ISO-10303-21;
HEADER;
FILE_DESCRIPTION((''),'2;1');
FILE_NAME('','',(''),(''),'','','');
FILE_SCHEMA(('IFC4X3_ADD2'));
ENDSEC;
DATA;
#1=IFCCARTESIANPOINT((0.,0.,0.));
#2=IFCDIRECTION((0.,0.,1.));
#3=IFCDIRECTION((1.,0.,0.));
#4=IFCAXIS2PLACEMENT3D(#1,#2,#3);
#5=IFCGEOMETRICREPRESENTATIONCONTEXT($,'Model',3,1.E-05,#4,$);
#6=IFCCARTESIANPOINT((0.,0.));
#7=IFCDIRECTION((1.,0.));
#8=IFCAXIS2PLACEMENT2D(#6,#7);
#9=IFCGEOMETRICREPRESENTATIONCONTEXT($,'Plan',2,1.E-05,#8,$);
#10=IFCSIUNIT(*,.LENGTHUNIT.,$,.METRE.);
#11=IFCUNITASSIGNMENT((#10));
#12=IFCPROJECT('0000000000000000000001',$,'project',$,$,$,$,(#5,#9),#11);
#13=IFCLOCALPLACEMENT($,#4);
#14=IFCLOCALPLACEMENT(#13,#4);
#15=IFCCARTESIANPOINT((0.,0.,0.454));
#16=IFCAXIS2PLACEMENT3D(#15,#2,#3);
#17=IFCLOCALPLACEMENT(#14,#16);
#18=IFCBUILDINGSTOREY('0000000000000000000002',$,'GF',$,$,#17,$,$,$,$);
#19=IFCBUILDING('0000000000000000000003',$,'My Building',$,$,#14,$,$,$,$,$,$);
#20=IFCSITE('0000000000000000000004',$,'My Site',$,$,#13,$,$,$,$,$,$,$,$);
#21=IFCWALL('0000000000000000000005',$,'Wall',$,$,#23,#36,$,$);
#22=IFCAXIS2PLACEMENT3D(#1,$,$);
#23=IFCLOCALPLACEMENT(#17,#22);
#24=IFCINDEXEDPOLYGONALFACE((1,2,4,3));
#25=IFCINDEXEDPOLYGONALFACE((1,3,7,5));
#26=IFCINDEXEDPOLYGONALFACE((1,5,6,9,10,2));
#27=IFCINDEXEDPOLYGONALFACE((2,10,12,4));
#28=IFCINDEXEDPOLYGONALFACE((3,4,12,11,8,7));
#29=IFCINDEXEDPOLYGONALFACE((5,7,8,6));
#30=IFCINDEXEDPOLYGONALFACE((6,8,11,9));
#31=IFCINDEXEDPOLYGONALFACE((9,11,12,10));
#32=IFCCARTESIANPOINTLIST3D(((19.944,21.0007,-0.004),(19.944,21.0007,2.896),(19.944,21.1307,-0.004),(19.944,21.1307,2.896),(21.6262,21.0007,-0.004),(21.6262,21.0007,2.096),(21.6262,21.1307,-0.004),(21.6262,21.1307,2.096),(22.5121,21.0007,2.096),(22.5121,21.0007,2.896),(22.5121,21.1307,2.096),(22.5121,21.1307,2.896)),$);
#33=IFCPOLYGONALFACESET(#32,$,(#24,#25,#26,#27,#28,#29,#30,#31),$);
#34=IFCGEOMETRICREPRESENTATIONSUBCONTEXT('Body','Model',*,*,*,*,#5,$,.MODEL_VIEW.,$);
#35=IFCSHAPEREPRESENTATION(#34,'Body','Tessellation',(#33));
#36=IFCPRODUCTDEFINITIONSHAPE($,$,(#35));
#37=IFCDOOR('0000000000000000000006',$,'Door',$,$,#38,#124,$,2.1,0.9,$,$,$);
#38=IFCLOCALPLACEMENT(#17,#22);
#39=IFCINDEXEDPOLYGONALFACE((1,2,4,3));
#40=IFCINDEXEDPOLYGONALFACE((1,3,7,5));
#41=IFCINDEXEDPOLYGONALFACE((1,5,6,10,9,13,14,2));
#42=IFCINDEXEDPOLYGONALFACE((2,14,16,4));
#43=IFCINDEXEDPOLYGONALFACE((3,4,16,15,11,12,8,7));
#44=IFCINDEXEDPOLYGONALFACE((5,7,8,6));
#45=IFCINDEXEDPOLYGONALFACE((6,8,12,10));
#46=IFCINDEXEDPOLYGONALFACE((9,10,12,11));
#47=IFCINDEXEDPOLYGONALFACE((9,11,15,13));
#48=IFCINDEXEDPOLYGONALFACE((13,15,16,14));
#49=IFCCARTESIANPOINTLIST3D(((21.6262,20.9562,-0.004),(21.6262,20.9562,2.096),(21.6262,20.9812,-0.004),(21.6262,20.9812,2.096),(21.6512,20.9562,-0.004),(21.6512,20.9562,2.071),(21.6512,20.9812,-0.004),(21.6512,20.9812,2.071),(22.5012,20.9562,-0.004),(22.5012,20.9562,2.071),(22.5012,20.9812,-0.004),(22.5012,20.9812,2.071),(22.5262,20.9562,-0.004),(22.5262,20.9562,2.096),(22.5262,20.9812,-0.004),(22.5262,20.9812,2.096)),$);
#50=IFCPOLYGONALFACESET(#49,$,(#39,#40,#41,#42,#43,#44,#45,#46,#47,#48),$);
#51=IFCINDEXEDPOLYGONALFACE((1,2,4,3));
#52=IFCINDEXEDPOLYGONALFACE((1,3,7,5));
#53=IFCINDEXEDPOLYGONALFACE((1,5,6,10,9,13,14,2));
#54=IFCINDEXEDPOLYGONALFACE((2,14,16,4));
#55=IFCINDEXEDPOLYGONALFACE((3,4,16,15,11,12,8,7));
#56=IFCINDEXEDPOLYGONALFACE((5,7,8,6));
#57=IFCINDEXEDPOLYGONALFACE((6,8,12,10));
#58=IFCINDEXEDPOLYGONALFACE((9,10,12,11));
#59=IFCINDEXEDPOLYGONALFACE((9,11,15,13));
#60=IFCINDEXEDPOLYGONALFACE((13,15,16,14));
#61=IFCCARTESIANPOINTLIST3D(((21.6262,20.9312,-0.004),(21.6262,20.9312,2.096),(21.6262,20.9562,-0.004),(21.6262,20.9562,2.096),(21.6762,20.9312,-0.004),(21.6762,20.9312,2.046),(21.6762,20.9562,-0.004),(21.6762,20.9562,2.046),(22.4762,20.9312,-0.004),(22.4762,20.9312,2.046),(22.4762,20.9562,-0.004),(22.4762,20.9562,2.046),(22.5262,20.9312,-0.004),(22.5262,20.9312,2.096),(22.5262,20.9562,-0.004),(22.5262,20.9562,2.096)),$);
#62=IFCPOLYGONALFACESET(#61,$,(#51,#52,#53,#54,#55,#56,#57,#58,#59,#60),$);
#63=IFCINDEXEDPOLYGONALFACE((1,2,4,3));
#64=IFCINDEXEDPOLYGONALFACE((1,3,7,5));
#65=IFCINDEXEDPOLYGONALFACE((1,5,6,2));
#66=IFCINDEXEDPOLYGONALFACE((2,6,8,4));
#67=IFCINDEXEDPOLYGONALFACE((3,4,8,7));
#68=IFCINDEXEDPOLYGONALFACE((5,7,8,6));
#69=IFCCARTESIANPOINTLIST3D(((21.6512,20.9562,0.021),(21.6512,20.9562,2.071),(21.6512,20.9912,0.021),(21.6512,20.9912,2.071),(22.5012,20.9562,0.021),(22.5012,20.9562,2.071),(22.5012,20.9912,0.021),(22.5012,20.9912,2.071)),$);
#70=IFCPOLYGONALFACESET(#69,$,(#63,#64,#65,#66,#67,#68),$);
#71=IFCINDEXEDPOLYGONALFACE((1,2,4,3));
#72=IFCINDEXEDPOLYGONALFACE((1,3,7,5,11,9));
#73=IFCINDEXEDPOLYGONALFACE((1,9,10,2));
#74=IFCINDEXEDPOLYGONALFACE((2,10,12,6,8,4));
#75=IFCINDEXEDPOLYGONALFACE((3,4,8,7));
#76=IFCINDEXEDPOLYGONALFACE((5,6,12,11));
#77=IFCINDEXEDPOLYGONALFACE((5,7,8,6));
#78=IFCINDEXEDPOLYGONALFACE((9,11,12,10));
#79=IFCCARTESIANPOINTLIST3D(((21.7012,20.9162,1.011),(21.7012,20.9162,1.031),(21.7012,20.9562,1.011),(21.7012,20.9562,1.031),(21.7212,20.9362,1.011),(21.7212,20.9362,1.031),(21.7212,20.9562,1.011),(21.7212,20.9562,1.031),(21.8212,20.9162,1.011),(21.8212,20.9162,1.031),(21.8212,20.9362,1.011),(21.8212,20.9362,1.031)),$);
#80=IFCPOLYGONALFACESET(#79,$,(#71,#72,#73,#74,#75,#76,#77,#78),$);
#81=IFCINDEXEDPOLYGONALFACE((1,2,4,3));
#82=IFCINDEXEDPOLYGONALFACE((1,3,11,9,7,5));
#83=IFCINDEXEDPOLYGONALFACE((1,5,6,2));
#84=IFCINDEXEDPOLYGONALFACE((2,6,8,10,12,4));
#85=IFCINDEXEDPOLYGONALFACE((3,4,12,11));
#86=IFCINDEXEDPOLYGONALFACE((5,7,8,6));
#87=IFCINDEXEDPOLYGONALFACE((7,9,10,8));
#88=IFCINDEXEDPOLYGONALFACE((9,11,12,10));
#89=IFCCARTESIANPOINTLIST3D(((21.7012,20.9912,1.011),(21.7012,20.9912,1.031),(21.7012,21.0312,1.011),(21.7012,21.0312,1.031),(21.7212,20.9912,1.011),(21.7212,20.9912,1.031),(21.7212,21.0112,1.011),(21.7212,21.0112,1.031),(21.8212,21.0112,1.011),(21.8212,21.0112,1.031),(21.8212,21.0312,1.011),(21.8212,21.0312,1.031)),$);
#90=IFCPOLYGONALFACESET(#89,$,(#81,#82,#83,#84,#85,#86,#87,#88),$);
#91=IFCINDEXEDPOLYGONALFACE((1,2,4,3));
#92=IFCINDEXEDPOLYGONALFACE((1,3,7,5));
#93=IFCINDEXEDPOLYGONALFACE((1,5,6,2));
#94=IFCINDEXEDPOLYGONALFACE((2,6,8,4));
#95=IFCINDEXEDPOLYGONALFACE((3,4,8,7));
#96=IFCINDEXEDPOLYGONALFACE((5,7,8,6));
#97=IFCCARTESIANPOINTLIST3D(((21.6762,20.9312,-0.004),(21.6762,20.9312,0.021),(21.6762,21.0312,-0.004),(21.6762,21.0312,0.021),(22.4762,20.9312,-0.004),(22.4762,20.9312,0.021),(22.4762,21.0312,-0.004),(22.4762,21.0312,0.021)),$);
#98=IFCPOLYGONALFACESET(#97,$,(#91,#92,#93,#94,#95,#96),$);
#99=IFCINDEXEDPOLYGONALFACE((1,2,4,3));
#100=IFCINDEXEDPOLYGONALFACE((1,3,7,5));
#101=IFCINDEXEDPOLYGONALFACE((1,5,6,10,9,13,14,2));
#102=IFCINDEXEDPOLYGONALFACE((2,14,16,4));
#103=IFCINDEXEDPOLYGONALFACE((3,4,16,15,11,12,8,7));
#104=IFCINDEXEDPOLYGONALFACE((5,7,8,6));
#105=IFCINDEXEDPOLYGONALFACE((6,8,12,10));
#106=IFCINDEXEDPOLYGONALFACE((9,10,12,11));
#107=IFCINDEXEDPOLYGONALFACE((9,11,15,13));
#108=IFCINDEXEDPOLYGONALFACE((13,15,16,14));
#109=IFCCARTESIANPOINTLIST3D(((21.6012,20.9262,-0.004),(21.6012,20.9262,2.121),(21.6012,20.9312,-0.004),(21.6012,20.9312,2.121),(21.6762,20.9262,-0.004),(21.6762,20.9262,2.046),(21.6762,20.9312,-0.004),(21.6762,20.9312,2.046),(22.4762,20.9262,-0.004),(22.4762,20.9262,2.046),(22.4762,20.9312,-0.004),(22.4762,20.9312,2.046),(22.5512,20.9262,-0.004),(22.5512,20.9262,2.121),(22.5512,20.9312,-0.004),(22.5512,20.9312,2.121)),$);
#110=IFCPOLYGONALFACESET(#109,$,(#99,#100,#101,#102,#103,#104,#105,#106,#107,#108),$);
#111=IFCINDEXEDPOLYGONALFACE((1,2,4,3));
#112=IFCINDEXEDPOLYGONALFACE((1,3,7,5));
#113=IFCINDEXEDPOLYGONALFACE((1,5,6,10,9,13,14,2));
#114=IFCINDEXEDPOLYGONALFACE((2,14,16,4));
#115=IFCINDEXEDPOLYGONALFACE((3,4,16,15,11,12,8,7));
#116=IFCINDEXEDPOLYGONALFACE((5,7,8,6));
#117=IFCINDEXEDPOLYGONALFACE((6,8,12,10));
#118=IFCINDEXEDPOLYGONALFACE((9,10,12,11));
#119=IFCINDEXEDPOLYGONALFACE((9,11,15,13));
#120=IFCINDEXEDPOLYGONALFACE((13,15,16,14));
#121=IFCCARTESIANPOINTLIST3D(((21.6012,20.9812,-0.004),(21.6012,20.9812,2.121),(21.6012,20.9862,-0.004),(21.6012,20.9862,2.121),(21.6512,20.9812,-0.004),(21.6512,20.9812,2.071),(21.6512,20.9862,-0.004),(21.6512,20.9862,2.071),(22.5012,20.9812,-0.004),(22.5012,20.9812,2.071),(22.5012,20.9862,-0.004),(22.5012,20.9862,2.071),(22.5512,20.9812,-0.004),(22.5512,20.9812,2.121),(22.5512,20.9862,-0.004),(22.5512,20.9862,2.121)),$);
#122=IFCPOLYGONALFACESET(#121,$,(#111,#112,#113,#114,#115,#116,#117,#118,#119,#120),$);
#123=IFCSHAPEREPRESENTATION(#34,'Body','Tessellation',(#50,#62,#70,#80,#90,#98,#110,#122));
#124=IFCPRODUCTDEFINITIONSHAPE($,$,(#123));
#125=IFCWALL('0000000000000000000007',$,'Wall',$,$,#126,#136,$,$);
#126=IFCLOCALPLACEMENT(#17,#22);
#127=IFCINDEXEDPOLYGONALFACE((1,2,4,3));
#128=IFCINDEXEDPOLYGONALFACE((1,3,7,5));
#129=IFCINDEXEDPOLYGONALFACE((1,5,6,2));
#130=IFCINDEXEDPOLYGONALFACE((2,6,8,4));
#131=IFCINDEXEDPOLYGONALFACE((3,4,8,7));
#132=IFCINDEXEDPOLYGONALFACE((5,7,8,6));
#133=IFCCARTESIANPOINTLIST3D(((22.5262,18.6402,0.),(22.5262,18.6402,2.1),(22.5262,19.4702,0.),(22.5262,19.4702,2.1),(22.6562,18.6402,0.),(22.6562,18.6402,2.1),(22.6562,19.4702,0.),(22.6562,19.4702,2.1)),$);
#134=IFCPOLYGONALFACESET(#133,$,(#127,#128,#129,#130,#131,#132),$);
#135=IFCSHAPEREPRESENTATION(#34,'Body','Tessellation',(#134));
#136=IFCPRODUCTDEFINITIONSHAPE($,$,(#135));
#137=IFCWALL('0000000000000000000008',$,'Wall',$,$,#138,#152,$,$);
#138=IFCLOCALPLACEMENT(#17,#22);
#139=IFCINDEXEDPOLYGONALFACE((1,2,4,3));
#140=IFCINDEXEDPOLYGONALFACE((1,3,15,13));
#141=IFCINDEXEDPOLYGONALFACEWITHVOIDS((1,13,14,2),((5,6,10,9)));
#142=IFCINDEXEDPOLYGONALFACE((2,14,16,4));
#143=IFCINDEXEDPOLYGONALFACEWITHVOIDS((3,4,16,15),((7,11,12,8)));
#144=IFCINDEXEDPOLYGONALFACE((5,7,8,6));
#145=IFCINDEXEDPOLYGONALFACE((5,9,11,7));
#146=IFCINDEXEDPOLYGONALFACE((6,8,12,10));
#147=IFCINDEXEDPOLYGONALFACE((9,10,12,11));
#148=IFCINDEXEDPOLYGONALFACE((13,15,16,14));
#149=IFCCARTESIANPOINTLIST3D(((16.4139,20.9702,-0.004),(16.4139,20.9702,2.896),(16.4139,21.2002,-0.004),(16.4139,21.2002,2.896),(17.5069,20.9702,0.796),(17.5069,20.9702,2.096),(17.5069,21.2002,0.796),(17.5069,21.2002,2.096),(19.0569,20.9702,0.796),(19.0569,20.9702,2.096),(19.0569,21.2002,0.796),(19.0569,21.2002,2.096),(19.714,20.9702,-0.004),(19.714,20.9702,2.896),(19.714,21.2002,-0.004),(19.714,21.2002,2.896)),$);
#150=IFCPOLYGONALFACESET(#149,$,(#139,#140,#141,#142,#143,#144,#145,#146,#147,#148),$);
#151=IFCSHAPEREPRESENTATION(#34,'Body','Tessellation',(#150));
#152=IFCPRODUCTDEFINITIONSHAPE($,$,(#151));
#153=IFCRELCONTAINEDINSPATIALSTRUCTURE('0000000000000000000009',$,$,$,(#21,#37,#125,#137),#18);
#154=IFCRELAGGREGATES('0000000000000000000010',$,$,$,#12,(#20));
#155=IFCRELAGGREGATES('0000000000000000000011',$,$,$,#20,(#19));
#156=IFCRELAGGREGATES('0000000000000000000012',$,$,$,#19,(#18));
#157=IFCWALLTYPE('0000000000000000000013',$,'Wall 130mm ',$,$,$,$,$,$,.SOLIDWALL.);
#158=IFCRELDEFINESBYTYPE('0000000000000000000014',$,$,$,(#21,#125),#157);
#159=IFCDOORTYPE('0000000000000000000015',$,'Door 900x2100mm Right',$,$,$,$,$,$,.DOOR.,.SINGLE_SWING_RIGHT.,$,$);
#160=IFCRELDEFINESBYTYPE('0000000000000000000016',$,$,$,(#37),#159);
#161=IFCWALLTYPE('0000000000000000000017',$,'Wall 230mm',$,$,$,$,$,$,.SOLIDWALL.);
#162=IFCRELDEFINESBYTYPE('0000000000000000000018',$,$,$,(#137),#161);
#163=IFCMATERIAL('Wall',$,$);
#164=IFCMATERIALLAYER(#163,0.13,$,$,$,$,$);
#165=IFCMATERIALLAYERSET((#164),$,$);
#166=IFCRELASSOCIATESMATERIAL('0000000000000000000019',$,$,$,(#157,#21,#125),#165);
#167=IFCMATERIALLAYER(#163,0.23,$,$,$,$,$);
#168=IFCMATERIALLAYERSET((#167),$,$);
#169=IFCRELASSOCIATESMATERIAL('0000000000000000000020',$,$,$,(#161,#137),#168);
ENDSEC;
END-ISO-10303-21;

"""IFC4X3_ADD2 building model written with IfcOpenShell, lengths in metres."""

from ifc_helpers import new_model, entity, si_unit, frame, origin_with_axes, origin_2d_with_axis, place, context, subcontext, project, spatial, line, indexed_curve, outline, extrude, clip, halfspace, shape, source, transform, mapped, material, layer, layer_set, layer_usage, type_object, type_shapes, element, fill, save


model = new_model("IFC4X3_ADD2")

# Units and contexts
model_context = context("Model", 3, precision=1e-05, world=origin_with_axes())
plan_context = context("Plan", 2, precision=1e-05, world=origin_2d_with_axis())
body_context_1 = subcontext(model_context, "Body", "Model", "MODEL_VIEW")
body_context_2 = subcontext(plan_context, "Body", "Plan", "PLAN_VIEW")
ifc_project = project(units=[si_unit("LENGTHUNIT", "METRE")], contexts=[model_context, plan_context])

# Site, building, storey
site_placement = place(None, origin_with_axes())
site = spatial("IfcSite", under=ifc_project, at=site_placement, Name="My Site")
building_placement = place(site_placement, origin_with_axes())
building = spatial("IfcBuilding", under=site, at=building_placement, Name="My Building")
storey_placement = place(building_placement, frame((0.0, 0.0, 0.454), z_axis=(0.0, 0.0, 1.0), x_axis=(1.0, 0.0, 0.0)))
storey = spatial("IfcBuildingStorey", under=building, at=storey_placement, Name="GF")

# Wall, opening, door
ifc_material_1 = material(Name="Wall")
ifc_layer_1 = layer(ifc_material_1, 0.13)
ifc_layer_set_1 = layer_set([ifc_layer_1])
ifc_layer_usage_1 = layer_usage(ifc_layer_set_1, "AXIS2", "POSITIVE", 0.0)
wall_type_1 = type_object("IfcWallType", Name="Wall 130mm ", PredefinedType="SOLIDWALL", material=ifc_layer_set_1)
wall_1_placement = place(storey_placement, frame((22.5121, 21.1307, -0.004), z_axis=(0.0, 0.0, 1.0), x_axis=(-1.0, 0.0, 0.0)))
wall_1 = element("IfcWall", 1, at=wall_1_placement, inside=storey, type_object=wall_type_1, material=ifc_layer_usage_1, Name="Wall", context=body_context_1, shape_type="SweptSolid", body=[
    extrude(outline(indexed_curve([(0.0, 0.0), (0.0, 0.13), (2.5681, 0.13), (2.5681, 0.0), (0.0, 0.0)], self_intersect=False)), origin_with_axes(), (0.0, 0.0, 1.0), 2.9),
])
shared_shape_1 = source(origin_with_axes(), body_context_1, "Body", "SweptSolid", [
    extrude(outline(indexed_curve([(0.0, 0.0), (0.9, 0.0), (0.9, 2.1), (0.0, 2.1)], segments=[line(1, 2, 3, 4, 1)])), frame((0.0, -0.6, 0.0), z_axis=(0.0, -1.0, 0.0), x_axis=(1.0, 0.0, 0.0)), (0.0, 0.0, -1.0), 1.2),
])
opening_1_placement = place(wall_1_placement, frame((0.8859, 0.1995, 0.0), z_axis=(0.0, 0.0, 1.0), x_axis=(-1.0, 0.0, 0.0)))
opening_1 = element("IfcOpeningElement", 2, at=opening_1_placement, cuts=wall_1, PredefinedType="OPENING", context=body_context_1, shape_type="MappedRepresentation", body=[
    mapped(shared_shape_1, transform((0.0, 0.0, 0.0), x_axis=(1.0, 0.0, 0.0), y_axis=(0.0, 1.0, 0.0), z_axis=(0.0, 0.0, 1.0), scale=1.0)),
])
door_type_1 = type_object("IfcDoorType", Name="Door 900x2100mm Right", OperationType="SINGLE_SWING_RIGHT", PredefinedType="DOOR")
shared_shape_2 = source(origin_with_axes(), body_context_1, "Body", "SweptSolid", [
    extrude(outline(indexed_curve([(0.0, 0.0), (0.0, 2.1), (0.9, 2.1), (0.9, 0.0), (0.875, 0.0), (0.875, 2.075), (0.025, 2.075), (0.025, 0.0)], segments=[line(1, 2, 3, 4, 5, 6, 7, 8, 1)])), frame((0.0, 0.025, 0.0), z_axis=(0.0, -1.0, 0.0), x_axis=(1.0, 0.0, 0.0)), (0.0, 0.0, -1.0), 0.025),
    extrude(outline(indexed_curve([(0.0, 0.0), (0.0, 2.1), (0.9, 2.1), (0.9, 0.0), (0.85, 0.0), (0.85, 2.05), (0.05, 2.05), (0.05, 0.0)], segments=[line(1, 2, 3, 4, 5, 6, 7, 8, 1)])), frame((0.0, 0.0, 0.0), z_axis=(0.0, -1.0, 0.0), x_axis=(1.0, 0.0, 0.0)), (0.0, 0.0, -1.0), 0.025),
    extrude(outline(indexed_curve([(0.0, 0.0), (0.85, 0.0), (0.85, 0.035), (0.0, 0.035)], segments=[line(1, 2, 3, 4, 1)])), frame((0.025, 0.025, 0.025), z_axis=(0.0, 0.0, 1.0), x_axis=(1.0, 0.0, 0.0)), (0.0, 0.0, 1.0), 2.05),
    extrude(outline(indexed_curve([(0.0, 0.0), (0.0, -0.04), (0.12, -0.04), (0.12, -0.02), (0.02, -0.02), (0.02, 0.0)], segments=[line(1, 2, 3, 4, 5, 6, 1)])), frame((0.075, 0.025, 1.015), z_axis=(0.0, 0.0, 1.0), x_axis=(1.0, 0.0, 0.0)), (0.0, 0.0, 1.0), 0.02),
    extrude(outline(indexed_curve([(0.0, 0.0), (0.0, 0.04), (0.12, 0.04), (0.12, 0.02), (0.02, 0.02), (0.02, 0.0)], segments=[line(1, 2, 3, 4, 5, 6, 1)])), frame((0.075, 0.06, 1.015), z_axis=(0.0, 0.0, 1.0), x_axis=(1.0, 0.0, 0.0)), (0.0, 0.0, 1.0), 0.02),
    extrude(outline(indexed_curve([(0.0, 0.0), (0.8, 0.0), (0.8, 0.1), (0.0, 0.1)], segments=[line(1, 2, 3, 4, 1)])), frame((0.05, 0.0, 0.0), z_axis=(0.0, 0.0, 1.0), x_axis=(1.0, 0.0, 0.0)), (0.0, 0.0, 1.0), 0.025),
    extrude(outline(indexed_curve([(0.0, 0.0), (0.0, 2.125), (0.95, 2.125), (0.95, 0.0), (0.875, 0.0), (0.875, 2.05), (0.075, 2.05), (0.075, 0.0)], segments=[line(1, 2, 3, 4, 5, 6, 7, 8, 1)])), frame((-0.025, -0.005, 0.0), z_axis=(0.0, -1.0, 0.0), x_axis=(1.0, 0.0, 0.0)), (0.0, 0.0, -1.0), 0.005),
    extrude(outline(indexed_curve([(0.0, 0.0), (0.0, 2.125), (0.95, 2.125), (0.95, 0.0), (0.9, 0.0), (0.9, 2.075), (0.05, 2.075), (0.05, 0.0)], segments=[line(1, 2, 3, 4, 5, 6, 7, 8, 1)])), frame((-0.025, 0.05, 0.0), z_axis=(0.0, -1.0, 0.0), x_axis=(1.0, 0.0, 0.0)), (0.0, 0.0, -1.0), 0.005),
])
shared_shape_3 = source(origin_with_axes(), body_context_2, "Body", "Curve2D", [
    entity("IfcIndexedPolyCurve", entity("IfcCartesianPointList2D", [[0.0, 0.0], [0.0, 0.05], [0.025, 0.05], [0.025, 0.025], [0.05, 0.025], [0.05, 0.0]]), [entity("IfcLineIndex", [1, 2, 3, 4, 5, 6, 1])]),
    entity("IfcIndexedPolyCurve", entity("IfcCartesianPointList2D", [[0.9, 0.0], [0.9, 0.05], [0.875, 0.05], [0.875, 0.025], [0.85, 0.025], [0.85, 0.0]]), [entity("IfcLineIndex", [1, 2, 3, 4, 5, 6, 1])]),
    entity("IfcTrimmedCurve", entity("IfcEllipse", entity("IfcAxis2Placement2D", entity("IfcCartesianPoint", [0.84, 0.05]), entity("IfcDirection", [1.0, 0.0])), 0.815, 0.85), [entity("IfcCartesianPoint", [0.84, 0.9])], [entity("IfcCartesianPoint", [0.025, 0.05])], True, "CARTESIAN"),
    entity("IfcIndexedPolyCurve", entity("IfcCartesianPointList2D", [[0.875, 0.05], [0.84, 0.05], [0.84, 0.9], [0.875, 0.9]]), [entity("IfcLineIndex", [1, 2, 3, 4, 1])]),
])
type_shapes(door_type_1, [shared_shape_2, shared_shape_3])
door_1_placement = place(opening_1_placement, frame((0.0, 0.0, 0.0), z_axis=(0.0, 0.0, 1.0), x_axis=(1.0, 0.0, 0.0)))
door_1 = element("IfcDoor", 3, at=door_1_placement, inside=storey, type_object=door_type_1, Name="Door", OverallHeight=2.1, OverallWidth=0.9, shapes=[
    shape(body_context_1, "Body", "MappedRepresentation", [mapped(shared_shape_2, transform((0.0, 0.0, 0.0), x_axis=(1.0, 0.0, 0.0), y_axis=(0.0, 1.0, 0.0), z_axis=(0.0, 0.0, 1.0), scale=1.0))]),
    shape(body_context_2, "Body", "MappedRepresentation", [mapped(shared_shape_3, transform((0.0, 0.0, 0.0), x_axis=(1.0, 0.0, 0.0), y_axis=(0.0, 1.0, 0.0), z_axis=(0.0, 0.0, 1.0), scale=1.0))]),
])
fill(opening_1, door_1)

# Wall
ifc_layer_usage_2 = layer_usage(ifc_layer_set_1, "AXIS2", "POSITIVE", 0.0)
wall_2_placement = place(storey_placement, frame((22.6562, 18.6402, 0.0), z_axis=(0.0, 0.0, 1.0), x_axis=(0.000002, 1.0, 0.0)))
element("IfcWall", 4, at=wall_2_placement, inside=storey, type_object=wall_type_1, material=ifc_layer_usage_2, Name="Wall", context=body_context_1, shape_type="Clipping", body=[
    clip(extrude(outline(indexed_curve([(0.0, 0.0), (0.0, 0.13), (0.83, 0.13), (0.83, 0.0), (0.0, 0.0)], self_intersect=False)), origin_with_axes(), (0.0, 0.0, 1.0), 2.554), halfspace(frame((0.0, 0.0, 2.1), z_axis=(0.0, 0.0, 1.0), x_axis=(-1.0, 0.0, 0.0)), False)),
])

# Wall, opening
ifc_layer_2 = layer(ifc_material_1, 0.23)
ifc_layer_set_2 = layer_set([ifc_layer_2])
ifc_layer_usage_3 = layer_usage(ifc_layer_set_2, "AXIS2", "POSITIVE", 0.0)
wall_type_2 = type_object("IfcWallType", Name="Wall 230mm", PredefinedType="SOLIDWALL", material=ifc_layer_set_2)
wall_3_placement = place(storey_placement, frame((19.714, 21.2002, -0.004), z_axis=(0.0, 0.0, 1.0), x_axis=(-1.0, 0.0, 0.0)))
wall_3 = element("IfcWall", 5, at=wall_3_placement, inside=storey, type_object=wall_type_2, material=ifc_layer_usage_3, Name="Wall", context=body_context_1, shape_type="SweptSolid", body=[
    extrude(outline(indexed_curve([(0.0, 0.0), (0.0, 0.23), (3.3, 0.23), (3.3, 0.0), (0.0, 0.0)], self_intersect=False)), origin_with_axes(), (0.0, 0.0, 1.0), 2.9),
])
shared_shape_4 = source(origin_with_axes(), body_context_1, "Body", "SweptSolid", [
    extrude(outline(indexed_curve([(0.0, 0.0), (1.55, 0.0), (1.55, 1.3), (0.0, 1.3)], segments=[line(1, 2, 3, 4, 1)])), frame((-0.775, -0.6, 0.0), z_axis=(0.0, -1.0, 0.0), x_axis=(1.0, 0.0, 0.0)), (0.0, 0.0, -1.0), 1.2),
])
opening_2_placement = place(wall_3_placement, frame((1.432, 0.0, 0.8), z_axis=(0.0, 0.0, 1.0), x_axis=(1.0, 0.0, 0.0)))
element("IfcOpeningElement", 6, at=opening_2_placement, cuts=wall_3, PredefinedType="OPENING", context=body_context_1, shape_type="MappedRepresentation", body=[
    mapped(shared_shape_4, transform((0.0, 0.0, 0.0), x_axis=(1.0, 0.0, 0.0), y_axis=(0.0, 1.0, 0.0), z_axis=(0.0, 0.0, 1.0), scale=1.0)),
])

save(model, "model.ifc")
